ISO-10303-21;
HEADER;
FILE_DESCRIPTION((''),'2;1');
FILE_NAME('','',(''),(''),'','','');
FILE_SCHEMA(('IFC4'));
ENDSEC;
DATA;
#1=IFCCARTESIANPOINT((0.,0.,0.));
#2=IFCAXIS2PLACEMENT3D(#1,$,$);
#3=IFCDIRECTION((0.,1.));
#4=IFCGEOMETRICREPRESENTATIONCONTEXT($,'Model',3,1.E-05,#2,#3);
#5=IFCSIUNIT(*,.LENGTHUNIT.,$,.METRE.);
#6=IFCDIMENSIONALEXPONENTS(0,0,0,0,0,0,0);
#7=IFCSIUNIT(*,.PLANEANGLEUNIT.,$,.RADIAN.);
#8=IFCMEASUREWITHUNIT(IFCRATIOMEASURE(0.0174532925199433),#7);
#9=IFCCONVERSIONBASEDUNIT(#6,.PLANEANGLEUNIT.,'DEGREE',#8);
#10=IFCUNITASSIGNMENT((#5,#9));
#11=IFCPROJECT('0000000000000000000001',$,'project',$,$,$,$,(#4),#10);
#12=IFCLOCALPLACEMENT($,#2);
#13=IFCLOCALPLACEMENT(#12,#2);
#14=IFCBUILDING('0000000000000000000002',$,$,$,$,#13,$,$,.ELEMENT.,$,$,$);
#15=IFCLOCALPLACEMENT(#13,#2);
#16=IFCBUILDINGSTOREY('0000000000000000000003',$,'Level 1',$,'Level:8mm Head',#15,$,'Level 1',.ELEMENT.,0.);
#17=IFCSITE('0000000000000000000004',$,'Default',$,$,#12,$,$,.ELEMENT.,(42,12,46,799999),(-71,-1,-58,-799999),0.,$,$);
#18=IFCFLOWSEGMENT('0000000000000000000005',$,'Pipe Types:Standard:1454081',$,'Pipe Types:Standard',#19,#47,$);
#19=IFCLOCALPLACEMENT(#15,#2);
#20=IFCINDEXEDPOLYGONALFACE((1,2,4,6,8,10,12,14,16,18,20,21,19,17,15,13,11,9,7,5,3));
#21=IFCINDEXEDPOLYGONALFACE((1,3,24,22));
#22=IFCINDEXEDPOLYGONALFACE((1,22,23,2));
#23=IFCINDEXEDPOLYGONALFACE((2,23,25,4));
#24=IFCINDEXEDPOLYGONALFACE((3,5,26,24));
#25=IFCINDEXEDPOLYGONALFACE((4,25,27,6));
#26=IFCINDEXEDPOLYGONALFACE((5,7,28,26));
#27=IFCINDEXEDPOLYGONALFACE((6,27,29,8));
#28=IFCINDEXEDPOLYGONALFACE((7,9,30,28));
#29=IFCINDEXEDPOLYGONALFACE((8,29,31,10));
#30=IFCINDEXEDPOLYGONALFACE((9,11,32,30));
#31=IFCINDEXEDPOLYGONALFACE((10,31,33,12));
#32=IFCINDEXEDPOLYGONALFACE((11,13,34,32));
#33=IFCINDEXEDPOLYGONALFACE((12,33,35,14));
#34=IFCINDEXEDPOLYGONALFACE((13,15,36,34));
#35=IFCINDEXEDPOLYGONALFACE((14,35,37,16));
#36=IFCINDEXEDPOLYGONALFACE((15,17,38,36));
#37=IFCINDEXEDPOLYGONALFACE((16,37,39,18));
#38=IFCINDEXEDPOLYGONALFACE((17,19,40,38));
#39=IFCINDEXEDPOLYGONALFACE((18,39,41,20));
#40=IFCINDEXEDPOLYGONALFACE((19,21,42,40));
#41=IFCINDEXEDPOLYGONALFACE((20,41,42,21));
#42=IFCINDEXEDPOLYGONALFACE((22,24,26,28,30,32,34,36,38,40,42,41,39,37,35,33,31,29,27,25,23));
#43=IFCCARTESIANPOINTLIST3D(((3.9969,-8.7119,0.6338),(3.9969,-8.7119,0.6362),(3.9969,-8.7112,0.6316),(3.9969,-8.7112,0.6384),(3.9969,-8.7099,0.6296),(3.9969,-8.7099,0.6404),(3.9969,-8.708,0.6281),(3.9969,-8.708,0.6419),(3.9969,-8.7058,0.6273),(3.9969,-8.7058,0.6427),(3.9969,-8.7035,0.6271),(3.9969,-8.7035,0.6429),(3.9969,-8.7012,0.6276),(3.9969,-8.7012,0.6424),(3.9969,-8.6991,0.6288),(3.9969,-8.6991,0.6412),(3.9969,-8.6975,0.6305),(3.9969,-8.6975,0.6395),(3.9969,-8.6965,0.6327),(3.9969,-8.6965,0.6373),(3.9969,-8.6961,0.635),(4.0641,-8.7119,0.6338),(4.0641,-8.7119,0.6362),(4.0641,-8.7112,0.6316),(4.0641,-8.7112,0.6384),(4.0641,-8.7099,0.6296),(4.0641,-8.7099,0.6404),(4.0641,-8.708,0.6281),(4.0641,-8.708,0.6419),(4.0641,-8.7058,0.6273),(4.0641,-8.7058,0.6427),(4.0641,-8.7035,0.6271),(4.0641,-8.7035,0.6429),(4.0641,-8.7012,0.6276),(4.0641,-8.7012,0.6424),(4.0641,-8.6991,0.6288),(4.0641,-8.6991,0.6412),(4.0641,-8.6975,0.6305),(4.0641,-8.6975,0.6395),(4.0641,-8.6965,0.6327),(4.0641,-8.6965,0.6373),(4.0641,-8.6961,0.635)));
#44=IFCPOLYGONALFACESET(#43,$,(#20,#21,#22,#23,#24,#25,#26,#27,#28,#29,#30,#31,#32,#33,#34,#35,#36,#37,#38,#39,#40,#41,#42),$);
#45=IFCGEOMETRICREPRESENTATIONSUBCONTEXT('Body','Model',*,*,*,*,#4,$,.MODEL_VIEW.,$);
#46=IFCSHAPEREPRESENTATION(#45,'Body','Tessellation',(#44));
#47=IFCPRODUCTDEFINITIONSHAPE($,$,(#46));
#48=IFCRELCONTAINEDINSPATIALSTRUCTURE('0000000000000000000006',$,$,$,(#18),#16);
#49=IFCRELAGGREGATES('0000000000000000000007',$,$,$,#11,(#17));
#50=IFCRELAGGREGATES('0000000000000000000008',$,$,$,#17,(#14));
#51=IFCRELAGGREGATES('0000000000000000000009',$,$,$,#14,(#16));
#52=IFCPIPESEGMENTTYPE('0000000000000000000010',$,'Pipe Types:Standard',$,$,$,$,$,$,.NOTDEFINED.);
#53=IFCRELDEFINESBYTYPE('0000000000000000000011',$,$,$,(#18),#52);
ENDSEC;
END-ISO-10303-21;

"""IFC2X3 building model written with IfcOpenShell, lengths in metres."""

from ifc_helpers import new_model, entity, si_unit, converted_unit, direction, frame, frame_2d, origin, place, context, subcontext, project, spatial, circle, extrude, type_object, element, save


model = new_model("IFC2X3")

# Units and contexts
model_context = context("Model", 3, precision=1e-05, world=origin(), true_north=direction((0.0, 1.0)))
body_context = subcontext(model_context, "Body", "Model", "MODEL_VIEW")
ifc_project = project(units=[si_unit("LENGTHUNIT", "METRE"), converted_unit("PLANEANGLEUNIT", "DEGREE", entity("IfcRatioMeasure", 0.0174532925199433), si_unit("PLANEANGLEUNIT", "RADIAN"), dimensions=[0, 0, 0, 0, 0, 0, 0])], contexts=[model_context])

# Site, building, storey
site_placement = place(None, origin())
site = spatial("IfcSite", under=ifc_project, at=site_placement, Name="Default", CompositionType="ELEMENT", RefLatitude=(42, 12, 46, 799999), RefLongitude=(-71, -1, -58, -799999), RefElevation=0.0)
building_placement = place(site_placement, origin())
building = spatial("IfcBuilding", under=site, at=building_placement, CompositionType="ELEMENT")
storey_placement = place(building_placement, origin())
storey = spatial("IfcBuildingStorey", under=building, at=storey_placement, Name="Level 1", ObjectType="Level:8mm Head", LongName="Level 1", CompositionType="ELEMENT", Elevation=0.0)

# Flow segment
pipe_segment_type = type_object("IfcPipeSegmentType", Name="Pipe Types:Standard", PredefinedType="NOTDEFINED")
flow_segment_1_placement = place(storey_placement, origin())
element("IfcFlowSegment", 1, at=flow_segment_1_placement, inside=storey, type_object=pipe_segment_type, Name="Pipe Types:Standard:1454081", ObjectType="Pipe Types:Standard", context=body_context, shape_type="SweptSolid", body=[
    extrude(circle(Radius=0.0079, at=frame_2d((0.0, 0.0), x_axis=(1.0, 0.0))), frame((3.9969, -8.7041, 0.635), z_axis=(1.0, 0.0, 0.0), x_axis=(0.0, 1.0, 0.0)), (0.0, 0.0, 1.0), 0.0672),
])

save(model, "model.ifc")
